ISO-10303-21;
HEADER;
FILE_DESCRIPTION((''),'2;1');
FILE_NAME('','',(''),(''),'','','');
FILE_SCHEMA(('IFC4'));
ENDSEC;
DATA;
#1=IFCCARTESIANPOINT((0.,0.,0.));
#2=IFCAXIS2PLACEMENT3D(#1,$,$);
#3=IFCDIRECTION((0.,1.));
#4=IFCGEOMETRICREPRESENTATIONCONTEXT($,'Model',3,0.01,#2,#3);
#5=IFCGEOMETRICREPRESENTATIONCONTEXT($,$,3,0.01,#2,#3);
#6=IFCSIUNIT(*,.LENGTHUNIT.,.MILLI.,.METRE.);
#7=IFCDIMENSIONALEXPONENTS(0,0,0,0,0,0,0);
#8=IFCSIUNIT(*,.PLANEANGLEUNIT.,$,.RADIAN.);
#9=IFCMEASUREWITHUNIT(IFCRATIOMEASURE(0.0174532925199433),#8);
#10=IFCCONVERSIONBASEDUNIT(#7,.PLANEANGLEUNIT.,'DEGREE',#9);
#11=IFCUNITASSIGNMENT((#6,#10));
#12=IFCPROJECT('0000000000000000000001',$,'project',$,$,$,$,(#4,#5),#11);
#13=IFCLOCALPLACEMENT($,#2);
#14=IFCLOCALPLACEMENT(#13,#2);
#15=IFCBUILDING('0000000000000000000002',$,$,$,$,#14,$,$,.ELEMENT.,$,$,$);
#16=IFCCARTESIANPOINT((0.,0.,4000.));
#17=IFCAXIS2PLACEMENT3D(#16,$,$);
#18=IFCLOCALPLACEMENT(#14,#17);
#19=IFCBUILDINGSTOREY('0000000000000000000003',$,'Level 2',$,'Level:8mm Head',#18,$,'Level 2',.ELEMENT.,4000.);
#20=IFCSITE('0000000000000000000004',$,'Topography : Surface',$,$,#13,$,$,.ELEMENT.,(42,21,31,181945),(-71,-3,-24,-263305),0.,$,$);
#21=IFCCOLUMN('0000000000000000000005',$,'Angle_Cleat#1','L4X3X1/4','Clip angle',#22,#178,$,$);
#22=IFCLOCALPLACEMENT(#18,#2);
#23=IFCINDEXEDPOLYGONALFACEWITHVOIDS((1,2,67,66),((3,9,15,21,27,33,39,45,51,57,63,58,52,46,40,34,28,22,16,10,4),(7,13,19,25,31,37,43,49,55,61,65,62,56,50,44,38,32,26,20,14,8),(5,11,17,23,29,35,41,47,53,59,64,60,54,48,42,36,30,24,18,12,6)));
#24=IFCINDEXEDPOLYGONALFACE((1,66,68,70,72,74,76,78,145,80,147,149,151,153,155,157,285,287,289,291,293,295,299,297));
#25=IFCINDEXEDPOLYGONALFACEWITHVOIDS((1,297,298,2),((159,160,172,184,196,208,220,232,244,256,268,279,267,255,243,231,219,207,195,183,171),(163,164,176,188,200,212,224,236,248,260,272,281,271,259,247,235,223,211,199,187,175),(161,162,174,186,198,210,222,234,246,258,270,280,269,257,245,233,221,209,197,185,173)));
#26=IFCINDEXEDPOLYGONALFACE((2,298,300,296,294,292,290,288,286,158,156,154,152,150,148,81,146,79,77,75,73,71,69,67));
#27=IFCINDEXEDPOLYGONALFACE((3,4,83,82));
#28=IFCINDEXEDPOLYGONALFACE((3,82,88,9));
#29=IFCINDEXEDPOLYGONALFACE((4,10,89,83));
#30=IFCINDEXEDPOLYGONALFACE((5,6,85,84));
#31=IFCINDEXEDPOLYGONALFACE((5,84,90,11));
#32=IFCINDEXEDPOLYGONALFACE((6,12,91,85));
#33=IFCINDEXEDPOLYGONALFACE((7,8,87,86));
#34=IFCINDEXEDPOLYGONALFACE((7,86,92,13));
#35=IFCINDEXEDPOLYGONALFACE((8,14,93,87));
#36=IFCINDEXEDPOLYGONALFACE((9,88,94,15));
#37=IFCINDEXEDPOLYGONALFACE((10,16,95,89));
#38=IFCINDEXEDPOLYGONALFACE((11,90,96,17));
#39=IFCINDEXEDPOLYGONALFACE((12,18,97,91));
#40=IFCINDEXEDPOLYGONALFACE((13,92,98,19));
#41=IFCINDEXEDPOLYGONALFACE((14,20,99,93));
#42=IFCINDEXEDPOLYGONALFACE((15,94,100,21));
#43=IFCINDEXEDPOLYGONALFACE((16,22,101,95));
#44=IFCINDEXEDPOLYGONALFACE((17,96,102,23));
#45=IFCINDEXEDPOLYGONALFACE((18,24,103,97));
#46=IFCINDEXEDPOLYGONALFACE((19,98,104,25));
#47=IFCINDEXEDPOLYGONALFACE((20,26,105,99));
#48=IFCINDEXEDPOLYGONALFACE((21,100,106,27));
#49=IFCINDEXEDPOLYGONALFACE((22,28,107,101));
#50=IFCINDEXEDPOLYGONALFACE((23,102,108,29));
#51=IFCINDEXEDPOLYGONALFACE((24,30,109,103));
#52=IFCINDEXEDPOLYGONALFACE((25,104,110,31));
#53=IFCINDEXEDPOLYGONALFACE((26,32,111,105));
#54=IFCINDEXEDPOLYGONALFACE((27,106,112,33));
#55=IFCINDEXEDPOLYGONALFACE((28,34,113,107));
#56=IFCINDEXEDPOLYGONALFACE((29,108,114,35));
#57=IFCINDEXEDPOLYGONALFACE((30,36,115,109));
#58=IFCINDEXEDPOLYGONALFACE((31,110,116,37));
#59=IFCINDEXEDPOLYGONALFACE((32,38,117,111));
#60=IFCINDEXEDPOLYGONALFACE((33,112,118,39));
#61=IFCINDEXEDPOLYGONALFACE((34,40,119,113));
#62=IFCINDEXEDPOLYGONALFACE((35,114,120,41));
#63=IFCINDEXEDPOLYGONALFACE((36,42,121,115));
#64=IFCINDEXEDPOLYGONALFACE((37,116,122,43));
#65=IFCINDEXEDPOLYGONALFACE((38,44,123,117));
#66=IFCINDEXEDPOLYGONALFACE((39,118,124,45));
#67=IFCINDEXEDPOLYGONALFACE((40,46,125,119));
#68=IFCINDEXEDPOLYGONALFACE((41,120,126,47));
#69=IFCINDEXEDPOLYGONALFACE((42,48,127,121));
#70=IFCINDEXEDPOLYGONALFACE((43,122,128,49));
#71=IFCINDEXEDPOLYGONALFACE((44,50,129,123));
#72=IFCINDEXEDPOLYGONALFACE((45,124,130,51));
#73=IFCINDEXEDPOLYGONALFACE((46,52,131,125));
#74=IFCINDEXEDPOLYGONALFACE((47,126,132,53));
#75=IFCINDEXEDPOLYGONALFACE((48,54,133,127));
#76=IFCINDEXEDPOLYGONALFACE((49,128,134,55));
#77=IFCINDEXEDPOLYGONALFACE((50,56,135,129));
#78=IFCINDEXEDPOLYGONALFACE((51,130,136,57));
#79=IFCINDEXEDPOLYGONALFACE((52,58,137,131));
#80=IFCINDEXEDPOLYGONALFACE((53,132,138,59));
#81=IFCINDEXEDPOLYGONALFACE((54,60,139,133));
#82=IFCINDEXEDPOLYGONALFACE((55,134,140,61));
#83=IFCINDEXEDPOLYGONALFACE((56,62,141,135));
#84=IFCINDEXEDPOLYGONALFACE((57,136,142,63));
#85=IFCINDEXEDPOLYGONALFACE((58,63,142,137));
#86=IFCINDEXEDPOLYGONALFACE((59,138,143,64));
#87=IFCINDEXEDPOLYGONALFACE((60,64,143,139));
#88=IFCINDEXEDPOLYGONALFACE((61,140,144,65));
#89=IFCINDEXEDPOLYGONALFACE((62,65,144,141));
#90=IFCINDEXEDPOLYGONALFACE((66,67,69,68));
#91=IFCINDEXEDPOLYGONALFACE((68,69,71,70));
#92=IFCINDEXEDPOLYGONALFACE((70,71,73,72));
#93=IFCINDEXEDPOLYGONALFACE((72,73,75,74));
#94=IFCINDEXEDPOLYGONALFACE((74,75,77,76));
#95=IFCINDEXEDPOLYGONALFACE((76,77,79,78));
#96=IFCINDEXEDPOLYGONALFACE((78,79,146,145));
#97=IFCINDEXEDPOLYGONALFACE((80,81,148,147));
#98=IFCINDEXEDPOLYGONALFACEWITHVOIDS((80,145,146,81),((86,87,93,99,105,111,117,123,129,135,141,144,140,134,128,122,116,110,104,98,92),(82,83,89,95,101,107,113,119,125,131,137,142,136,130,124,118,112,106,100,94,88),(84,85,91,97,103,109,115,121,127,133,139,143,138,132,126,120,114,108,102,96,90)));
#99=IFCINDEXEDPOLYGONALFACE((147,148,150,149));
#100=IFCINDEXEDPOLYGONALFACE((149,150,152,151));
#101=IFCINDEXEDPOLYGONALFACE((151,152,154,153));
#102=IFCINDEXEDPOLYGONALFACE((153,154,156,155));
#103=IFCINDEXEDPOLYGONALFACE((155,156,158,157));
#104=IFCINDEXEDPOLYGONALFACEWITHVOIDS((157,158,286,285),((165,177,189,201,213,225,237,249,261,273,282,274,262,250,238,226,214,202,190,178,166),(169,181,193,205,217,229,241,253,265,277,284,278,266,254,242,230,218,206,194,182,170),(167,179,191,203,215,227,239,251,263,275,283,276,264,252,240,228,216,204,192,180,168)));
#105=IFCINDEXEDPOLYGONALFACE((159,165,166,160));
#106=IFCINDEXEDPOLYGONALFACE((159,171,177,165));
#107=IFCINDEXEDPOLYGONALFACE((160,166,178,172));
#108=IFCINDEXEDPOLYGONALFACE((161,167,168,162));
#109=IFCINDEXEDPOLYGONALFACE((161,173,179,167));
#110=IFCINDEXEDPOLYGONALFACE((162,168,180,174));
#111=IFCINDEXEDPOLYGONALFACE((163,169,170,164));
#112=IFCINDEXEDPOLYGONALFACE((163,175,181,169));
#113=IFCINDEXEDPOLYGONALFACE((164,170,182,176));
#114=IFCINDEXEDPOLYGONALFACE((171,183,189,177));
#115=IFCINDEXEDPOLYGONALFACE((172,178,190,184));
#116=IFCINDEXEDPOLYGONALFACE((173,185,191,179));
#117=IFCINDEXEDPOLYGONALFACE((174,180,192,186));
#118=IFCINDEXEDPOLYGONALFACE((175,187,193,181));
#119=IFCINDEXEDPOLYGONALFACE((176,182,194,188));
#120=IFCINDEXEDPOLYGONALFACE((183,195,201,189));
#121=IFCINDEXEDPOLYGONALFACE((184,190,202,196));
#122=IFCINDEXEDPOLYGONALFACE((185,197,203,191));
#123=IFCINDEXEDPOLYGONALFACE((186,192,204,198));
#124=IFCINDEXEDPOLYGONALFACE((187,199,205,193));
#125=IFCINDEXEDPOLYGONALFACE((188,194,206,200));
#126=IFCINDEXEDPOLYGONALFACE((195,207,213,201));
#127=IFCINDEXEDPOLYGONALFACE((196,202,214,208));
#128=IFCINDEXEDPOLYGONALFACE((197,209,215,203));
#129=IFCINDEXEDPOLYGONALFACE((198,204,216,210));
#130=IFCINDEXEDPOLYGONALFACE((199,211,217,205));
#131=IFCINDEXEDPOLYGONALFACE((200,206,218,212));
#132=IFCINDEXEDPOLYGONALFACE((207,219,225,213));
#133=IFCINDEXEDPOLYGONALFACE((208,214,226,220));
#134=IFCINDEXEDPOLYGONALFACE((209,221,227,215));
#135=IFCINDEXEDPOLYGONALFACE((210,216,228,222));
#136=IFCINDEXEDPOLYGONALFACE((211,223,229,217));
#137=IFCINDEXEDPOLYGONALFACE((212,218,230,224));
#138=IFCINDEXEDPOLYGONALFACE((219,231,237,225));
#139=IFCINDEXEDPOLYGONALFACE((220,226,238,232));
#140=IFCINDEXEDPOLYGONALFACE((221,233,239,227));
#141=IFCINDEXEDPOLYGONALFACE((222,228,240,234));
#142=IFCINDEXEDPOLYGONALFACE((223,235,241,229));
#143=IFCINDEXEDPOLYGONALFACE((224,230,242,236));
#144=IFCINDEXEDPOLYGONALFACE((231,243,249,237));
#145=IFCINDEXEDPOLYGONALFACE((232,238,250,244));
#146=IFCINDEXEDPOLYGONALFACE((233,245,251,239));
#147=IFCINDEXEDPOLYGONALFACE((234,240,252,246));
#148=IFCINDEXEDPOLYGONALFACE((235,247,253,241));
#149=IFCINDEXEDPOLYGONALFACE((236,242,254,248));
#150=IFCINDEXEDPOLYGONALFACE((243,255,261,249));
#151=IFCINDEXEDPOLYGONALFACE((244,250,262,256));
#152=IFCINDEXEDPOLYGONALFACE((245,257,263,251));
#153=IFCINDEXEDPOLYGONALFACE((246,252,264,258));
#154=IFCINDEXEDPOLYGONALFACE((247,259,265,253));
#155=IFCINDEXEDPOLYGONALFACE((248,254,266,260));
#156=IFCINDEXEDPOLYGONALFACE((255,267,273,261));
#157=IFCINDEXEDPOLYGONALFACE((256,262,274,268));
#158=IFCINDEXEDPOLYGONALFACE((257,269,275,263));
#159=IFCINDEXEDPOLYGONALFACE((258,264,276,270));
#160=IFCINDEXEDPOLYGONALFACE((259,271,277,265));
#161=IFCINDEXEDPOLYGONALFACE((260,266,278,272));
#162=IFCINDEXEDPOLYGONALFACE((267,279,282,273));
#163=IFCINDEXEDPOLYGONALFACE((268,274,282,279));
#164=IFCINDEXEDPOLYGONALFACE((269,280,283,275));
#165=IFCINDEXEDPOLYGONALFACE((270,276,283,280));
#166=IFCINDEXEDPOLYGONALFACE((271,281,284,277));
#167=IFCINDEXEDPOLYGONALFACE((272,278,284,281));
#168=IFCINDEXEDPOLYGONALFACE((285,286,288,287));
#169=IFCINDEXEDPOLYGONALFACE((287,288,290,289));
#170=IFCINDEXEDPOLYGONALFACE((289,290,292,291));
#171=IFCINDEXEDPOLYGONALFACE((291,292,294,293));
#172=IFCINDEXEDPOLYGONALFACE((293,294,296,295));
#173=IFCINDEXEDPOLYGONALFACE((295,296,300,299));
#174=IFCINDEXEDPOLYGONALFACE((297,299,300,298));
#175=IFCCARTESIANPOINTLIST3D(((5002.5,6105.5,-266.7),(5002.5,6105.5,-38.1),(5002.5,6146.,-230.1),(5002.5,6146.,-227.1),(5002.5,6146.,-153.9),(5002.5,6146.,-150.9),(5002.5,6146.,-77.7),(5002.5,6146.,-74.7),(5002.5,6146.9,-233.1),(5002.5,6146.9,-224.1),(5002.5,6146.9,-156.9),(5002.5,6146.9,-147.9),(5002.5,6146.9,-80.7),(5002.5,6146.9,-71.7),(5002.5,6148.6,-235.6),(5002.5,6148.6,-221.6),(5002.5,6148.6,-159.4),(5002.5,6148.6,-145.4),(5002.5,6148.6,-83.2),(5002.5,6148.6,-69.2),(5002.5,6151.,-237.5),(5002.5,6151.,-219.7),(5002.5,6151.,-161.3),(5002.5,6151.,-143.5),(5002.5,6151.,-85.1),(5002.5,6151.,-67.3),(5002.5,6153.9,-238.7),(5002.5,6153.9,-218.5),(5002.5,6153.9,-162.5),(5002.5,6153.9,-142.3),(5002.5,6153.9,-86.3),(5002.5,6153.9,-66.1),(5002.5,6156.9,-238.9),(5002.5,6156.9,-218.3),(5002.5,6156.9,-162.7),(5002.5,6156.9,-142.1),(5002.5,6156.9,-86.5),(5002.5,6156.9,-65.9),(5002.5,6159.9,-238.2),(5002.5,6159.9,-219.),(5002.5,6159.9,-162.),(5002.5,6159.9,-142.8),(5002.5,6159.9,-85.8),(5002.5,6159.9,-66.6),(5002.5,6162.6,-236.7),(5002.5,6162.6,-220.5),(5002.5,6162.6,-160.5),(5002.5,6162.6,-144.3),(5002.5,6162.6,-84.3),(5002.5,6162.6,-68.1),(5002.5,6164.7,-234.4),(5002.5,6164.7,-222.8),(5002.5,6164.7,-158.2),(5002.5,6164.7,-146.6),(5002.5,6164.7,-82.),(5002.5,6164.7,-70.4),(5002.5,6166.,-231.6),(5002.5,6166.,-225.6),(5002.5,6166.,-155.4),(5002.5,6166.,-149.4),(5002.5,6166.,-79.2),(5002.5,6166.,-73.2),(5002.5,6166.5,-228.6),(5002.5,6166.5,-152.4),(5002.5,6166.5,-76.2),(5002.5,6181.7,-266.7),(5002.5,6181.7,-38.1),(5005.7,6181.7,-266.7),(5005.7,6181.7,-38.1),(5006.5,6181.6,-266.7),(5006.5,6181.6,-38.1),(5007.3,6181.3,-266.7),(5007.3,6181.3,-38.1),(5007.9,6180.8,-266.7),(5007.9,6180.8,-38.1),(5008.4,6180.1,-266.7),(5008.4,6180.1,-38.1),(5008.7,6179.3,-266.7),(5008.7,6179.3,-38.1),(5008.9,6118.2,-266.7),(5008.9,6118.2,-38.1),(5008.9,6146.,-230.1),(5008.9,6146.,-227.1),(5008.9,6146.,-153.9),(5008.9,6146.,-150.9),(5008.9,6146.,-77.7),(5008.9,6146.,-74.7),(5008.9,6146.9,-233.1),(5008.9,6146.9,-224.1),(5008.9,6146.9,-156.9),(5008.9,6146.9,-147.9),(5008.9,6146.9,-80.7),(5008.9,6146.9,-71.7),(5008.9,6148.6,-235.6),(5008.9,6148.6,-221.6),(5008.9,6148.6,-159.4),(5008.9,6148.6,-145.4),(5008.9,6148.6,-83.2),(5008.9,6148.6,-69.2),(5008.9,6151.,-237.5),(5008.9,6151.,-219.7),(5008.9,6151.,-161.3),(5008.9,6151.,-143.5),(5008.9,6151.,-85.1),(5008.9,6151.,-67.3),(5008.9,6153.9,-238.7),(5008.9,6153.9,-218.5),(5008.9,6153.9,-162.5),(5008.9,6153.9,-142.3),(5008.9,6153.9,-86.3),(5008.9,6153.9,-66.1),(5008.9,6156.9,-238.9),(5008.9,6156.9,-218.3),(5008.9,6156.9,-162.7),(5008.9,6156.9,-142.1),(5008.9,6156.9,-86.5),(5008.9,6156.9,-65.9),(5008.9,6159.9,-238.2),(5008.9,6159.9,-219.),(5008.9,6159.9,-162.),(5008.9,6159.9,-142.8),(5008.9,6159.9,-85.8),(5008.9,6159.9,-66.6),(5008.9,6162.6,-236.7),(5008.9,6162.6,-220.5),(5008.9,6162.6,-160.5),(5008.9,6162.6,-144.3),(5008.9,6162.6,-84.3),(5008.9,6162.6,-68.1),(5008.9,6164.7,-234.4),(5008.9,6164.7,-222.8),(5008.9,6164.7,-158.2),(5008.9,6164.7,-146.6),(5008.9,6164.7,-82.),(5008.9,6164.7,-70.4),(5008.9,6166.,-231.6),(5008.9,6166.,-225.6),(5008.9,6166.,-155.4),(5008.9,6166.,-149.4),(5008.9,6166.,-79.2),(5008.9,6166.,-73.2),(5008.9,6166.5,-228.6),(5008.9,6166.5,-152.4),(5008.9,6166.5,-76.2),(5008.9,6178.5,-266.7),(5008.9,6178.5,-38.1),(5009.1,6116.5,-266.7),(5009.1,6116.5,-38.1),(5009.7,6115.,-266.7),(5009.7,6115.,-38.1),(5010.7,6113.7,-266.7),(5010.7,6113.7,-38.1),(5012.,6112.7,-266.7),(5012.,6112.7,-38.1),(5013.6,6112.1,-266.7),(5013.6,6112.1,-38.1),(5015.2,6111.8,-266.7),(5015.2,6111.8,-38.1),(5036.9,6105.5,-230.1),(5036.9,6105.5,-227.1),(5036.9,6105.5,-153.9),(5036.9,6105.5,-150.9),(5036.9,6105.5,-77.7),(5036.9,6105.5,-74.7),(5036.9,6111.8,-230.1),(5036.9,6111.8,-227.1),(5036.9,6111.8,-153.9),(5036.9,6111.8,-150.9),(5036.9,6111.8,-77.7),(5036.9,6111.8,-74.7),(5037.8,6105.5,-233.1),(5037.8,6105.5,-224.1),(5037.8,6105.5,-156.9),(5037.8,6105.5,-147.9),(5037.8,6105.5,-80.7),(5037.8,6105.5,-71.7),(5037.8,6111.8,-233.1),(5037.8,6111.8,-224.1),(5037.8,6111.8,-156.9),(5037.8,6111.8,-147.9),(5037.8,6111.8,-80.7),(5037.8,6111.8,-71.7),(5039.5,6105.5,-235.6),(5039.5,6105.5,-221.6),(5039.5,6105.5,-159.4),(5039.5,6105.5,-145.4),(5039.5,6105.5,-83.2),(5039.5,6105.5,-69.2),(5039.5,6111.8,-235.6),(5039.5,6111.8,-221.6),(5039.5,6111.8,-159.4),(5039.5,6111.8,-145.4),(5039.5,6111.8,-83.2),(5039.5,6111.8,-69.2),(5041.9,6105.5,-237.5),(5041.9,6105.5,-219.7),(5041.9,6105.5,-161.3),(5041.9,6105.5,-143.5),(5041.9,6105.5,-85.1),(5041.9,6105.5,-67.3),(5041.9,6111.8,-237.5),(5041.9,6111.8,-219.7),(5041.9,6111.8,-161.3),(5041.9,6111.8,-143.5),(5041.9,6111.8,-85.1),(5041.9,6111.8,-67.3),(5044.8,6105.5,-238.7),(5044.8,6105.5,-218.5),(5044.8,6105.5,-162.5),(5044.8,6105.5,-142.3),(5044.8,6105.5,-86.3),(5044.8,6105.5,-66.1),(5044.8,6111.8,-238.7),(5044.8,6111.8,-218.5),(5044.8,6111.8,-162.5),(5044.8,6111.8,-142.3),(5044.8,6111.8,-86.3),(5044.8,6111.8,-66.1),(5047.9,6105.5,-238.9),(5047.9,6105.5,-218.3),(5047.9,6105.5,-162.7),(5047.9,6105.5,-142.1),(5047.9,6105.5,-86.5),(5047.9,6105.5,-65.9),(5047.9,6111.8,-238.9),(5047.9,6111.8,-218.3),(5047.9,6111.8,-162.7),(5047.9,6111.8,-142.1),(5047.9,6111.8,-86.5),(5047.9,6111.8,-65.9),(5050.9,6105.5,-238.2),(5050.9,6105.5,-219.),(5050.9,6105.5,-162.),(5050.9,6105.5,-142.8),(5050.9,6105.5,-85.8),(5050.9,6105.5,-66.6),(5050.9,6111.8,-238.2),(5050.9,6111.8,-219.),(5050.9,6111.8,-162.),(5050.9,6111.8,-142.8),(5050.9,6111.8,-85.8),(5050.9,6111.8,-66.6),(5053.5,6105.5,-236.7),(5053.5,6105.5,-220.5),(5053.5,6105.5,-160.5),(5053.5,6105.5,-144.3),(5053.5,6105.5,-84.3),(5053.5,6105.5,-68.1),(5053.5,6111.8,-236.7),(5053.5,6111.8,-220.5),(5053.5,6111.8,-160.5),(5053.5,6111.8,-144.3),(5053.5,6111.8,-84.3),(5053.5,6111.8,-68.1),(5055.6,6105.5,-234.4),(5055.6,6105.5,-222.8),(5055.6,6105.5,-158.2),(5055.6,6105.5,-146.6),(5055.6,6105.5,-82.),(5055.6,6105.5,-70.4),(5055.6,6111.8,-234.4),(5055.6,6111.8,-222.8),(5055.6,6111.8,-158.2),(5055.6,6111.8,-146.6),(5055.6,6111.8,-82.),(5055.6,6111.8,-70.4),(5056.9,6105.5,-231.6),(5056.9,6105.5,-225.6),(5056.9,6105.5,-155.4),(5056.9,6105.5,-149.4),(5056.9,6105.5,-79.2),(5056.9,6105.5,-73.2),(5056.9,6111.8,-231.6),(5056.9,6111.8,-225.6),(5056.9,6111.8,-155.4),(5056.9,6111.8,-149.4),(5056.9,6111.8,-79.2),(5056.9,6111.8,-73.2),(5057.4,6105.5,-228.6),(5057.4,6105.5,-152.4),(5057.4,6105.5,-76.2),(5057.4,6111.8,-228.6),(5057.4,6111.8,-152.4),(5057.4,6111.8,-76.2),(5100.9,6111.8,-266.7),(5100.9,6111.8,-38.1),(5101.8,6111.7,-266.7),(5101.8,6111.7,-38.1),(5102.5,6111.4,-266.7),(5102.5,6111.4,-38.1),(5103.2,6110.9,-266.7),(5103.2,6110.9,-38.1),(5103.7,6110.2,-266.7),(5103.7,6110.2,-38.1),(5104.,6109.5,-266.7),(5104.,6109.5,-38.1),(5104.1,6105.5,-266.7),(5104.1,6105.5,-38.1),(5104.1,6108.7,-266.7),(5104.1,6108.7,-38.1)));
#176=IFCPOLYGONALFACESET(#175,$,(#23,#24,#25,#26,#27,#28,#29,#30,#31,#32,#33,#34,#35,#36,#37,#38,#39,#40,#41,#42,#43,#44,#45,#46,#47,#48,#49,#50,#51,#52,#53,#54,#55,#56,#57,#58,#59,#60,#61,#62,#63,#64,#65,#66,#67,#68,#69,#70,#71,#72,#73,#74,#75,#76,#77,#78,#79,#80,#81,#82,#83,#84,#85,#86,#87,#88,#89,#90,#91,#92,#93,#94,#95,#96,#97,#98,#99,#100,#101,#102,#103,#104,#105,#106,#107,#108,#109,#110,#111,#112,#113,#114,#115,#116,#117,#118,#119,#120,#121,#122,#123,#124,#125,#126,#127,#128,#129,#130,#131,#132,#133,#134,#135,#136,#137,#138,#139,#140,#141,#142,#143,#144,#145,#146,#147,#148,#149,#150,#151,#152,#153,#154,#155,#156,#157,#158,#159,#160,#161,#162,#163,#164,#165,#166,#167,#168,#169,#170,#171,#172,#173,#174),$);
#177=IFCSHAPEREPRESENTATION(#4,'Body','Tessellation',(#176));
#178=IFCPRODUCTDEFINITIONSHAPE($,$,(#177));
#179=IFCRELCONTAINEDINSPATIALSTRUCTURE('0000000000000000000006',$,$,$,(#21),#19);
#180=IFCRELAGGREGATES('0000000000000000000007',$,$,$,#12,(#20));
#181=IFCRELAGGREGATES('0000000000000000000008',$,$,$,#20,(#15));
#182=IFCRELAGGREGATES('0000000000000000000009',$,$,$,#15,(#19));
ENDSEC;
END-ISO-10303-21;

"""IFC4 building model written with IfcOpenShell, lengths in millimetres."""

from ifc_helpers import new_model, entity, si_unit, converted_unit, direction, frame, frame_2d, origin, origin_2d_with_axis, place, context, project, spatial, circle, l_section, extrude, element, save


model = new_model("IFC4")

# Units and contexts
model_context = context("Model", 3, precision=0.01, world=origin(), true_north=direction((0.0, 1.0)))
context_of_model = context(None, 3, precision=0.01, world=origin(), true_north=direction((0.0, 1.0)))
ifc_project = project(units=[si_unit("LENGTHUNIT", "METRE", prefix="MILLI"), converted_unit("PLANEANGLEUNIT", "DEGREE", entity("IfcRatioMeasure", 0.0174532925199433), si_unit("PLANEANGLEUNIT", "RADIAN"), dimensions=[0, 0, 0, 0, 0, 0, 0])], contexts=[model_context, context_of_model])

# Site, building, storey
site_placement = place(None, origin())
site = spatial("IfcSite", under=ifc_project, at=site_placement, Name="Topography : Surface", CompositionType="ELEMENT", RefLatitude=(42, 21, 31, 181945), RefLongitude=(-71, -3, -24, -263305), RefElevation=0.0)
building_placement = place(site_placement, origin())
building = spatial("IfcBuilding", under=site, at=building_placement, CompositionType="ELEMENT")
storey_placement = place(building_placement, frame((0.0, 0.0, 4000.0)))
storey = spatial("IfcBuildingStorey", under=building, at=storey_placement, Name="Level 2", ObjectType="Level:8mm Head", LongName="Level 2", CompositionType="ELEMENT", Elevation=4000.0)

# Column, openings
column_1_placement = place(storey_placement, frame((5033.6, 6123.8, -266.7), z_axis=(0.0, 0.0, -1.0), x_axis=(0.0, 1.0, 0.0)))
column_1 = element("IfcColumn", 1, at=column_1_placement, inside=storey, Name="Angle_Cleat#1", Description="L4X3X1/4", ObjectType="Clip angle", context=model_context, shape_type="SweptSolid", body=[
    extrude(l_section(Depth=101.6, Width=76.2, Thickness=6.3, FilletRadius=6.3, EdgeRadius=3.2, at=frame_2d((19.8, 19.7))), origin(), (0.0, 0.0, -1.0), 228.6),
])
opening_1_placement = place(column_1_placement, frame((32.4, -31.5, -114.3), z_axis=(0.0, 1.0, 0.0), x_axis=(1.0, 0.0, 0.0)))
element("IfcOpeningElement", 2, at=opening_1_placement, cuts=column_1, ObjectType="Opening", context=model_context, shape_type="SweptSolid", body=[
    extrude(circle(Radius=10.3, at=origin_2d_with_axis()), origin(), (0.0, 0.0, 1.0), 7.3),
])
opening_2_placement = place(column_1_placement, frame((32.4, -31.5, -114.3), z_axis=(0.0, 1.0, 0.0), x_axis=(1.0, 0.0, 0.0)))
element("IfcOpeningElement", 3, at=opening_2_placement, cuts=column_1, ObjectType="Opening", context=model_context, shape_type="SweptSolid", body=[
    extrude(circle(Radius=10.3, at=frame_2d((0.0, 76.2), x_axis=(1.0, 0.0))), origin(), (0.0, 0.0, 1.0), 7.3),
])
opening_3_placement = place(column_1_placement, frame((32.4, -31.5, -114.3), z_axis=(0.0, 1.0, 0.0), x_axis=(1.0, 0.0, 0.0)))
element("IfcOpeningElement", 4, at=opening_3_placement, cuts=column_1, ObjectType="Opening", context=model_context, shape_type="SweptSolid", body=[
    extrude(circle(Radius=10.3, at=frame_2d((0.0, -76.2), x_axis=(1.0, 0.0))), origin(), (0.0, 0.0, 1.0), 7.3),
])
opening_4_placement = place(column_1_placement, frame((-18.9, 13.5, -114.3), z_axis=(1.0, 0.0, 0.0), x_axis=(0.0, 1.0, 0.0)))
element("IfcOpeningElement", 5, at=opening_4_placement, cuts=column_1, ObjectType="Opening", context=model_context, shape_type="SweptSolid", body=[
    extrude(circle(Radius=10.3, at=origin_2d_with_axis()), origin(), (0.0, 0.0, 1.0), 7.3),
])
opening_5_placement = place(column_1_placement, frame((-18.9, 13.5, -114.3), z_axis=(1.0, 0.0, 0.0), x_axis=(0.0, 1.0, 0.0)))
element("IfcOpeningElement", 6, at=opening_5_placement, cuts=column_1, ObjectType="Opening", context=model_context, shape_type="SweptSolid", body=[
    extrude(circle(Radius=10.3, at=frame_2d((0.0, 76.2), x_axis=(1.0, 0.0))), origin(), (0.0, 0.0, 1.0), 7.3),
])
opening_6_placement = place(column_1_placement, frame((-18.9, 13.5, -114.3), z_axis=(1.0, 0.0, 0.0), x_axis=(0.0, 1.0, 0.0)))
element("IfcOpeningElement", 7, at=opening_6_placement, cuts=column_1, ObjectType="Opening", context=model_context, shape_type="SweptSolid", body=[
    extrude(circle(Radius=10.3, at=frame_2d((0.0, -76.2), x_axis=(1.0, 0.0))), origin(), (0.0, 0.0, 1.0), 7.3),
])

save(model, "model.ifc")
